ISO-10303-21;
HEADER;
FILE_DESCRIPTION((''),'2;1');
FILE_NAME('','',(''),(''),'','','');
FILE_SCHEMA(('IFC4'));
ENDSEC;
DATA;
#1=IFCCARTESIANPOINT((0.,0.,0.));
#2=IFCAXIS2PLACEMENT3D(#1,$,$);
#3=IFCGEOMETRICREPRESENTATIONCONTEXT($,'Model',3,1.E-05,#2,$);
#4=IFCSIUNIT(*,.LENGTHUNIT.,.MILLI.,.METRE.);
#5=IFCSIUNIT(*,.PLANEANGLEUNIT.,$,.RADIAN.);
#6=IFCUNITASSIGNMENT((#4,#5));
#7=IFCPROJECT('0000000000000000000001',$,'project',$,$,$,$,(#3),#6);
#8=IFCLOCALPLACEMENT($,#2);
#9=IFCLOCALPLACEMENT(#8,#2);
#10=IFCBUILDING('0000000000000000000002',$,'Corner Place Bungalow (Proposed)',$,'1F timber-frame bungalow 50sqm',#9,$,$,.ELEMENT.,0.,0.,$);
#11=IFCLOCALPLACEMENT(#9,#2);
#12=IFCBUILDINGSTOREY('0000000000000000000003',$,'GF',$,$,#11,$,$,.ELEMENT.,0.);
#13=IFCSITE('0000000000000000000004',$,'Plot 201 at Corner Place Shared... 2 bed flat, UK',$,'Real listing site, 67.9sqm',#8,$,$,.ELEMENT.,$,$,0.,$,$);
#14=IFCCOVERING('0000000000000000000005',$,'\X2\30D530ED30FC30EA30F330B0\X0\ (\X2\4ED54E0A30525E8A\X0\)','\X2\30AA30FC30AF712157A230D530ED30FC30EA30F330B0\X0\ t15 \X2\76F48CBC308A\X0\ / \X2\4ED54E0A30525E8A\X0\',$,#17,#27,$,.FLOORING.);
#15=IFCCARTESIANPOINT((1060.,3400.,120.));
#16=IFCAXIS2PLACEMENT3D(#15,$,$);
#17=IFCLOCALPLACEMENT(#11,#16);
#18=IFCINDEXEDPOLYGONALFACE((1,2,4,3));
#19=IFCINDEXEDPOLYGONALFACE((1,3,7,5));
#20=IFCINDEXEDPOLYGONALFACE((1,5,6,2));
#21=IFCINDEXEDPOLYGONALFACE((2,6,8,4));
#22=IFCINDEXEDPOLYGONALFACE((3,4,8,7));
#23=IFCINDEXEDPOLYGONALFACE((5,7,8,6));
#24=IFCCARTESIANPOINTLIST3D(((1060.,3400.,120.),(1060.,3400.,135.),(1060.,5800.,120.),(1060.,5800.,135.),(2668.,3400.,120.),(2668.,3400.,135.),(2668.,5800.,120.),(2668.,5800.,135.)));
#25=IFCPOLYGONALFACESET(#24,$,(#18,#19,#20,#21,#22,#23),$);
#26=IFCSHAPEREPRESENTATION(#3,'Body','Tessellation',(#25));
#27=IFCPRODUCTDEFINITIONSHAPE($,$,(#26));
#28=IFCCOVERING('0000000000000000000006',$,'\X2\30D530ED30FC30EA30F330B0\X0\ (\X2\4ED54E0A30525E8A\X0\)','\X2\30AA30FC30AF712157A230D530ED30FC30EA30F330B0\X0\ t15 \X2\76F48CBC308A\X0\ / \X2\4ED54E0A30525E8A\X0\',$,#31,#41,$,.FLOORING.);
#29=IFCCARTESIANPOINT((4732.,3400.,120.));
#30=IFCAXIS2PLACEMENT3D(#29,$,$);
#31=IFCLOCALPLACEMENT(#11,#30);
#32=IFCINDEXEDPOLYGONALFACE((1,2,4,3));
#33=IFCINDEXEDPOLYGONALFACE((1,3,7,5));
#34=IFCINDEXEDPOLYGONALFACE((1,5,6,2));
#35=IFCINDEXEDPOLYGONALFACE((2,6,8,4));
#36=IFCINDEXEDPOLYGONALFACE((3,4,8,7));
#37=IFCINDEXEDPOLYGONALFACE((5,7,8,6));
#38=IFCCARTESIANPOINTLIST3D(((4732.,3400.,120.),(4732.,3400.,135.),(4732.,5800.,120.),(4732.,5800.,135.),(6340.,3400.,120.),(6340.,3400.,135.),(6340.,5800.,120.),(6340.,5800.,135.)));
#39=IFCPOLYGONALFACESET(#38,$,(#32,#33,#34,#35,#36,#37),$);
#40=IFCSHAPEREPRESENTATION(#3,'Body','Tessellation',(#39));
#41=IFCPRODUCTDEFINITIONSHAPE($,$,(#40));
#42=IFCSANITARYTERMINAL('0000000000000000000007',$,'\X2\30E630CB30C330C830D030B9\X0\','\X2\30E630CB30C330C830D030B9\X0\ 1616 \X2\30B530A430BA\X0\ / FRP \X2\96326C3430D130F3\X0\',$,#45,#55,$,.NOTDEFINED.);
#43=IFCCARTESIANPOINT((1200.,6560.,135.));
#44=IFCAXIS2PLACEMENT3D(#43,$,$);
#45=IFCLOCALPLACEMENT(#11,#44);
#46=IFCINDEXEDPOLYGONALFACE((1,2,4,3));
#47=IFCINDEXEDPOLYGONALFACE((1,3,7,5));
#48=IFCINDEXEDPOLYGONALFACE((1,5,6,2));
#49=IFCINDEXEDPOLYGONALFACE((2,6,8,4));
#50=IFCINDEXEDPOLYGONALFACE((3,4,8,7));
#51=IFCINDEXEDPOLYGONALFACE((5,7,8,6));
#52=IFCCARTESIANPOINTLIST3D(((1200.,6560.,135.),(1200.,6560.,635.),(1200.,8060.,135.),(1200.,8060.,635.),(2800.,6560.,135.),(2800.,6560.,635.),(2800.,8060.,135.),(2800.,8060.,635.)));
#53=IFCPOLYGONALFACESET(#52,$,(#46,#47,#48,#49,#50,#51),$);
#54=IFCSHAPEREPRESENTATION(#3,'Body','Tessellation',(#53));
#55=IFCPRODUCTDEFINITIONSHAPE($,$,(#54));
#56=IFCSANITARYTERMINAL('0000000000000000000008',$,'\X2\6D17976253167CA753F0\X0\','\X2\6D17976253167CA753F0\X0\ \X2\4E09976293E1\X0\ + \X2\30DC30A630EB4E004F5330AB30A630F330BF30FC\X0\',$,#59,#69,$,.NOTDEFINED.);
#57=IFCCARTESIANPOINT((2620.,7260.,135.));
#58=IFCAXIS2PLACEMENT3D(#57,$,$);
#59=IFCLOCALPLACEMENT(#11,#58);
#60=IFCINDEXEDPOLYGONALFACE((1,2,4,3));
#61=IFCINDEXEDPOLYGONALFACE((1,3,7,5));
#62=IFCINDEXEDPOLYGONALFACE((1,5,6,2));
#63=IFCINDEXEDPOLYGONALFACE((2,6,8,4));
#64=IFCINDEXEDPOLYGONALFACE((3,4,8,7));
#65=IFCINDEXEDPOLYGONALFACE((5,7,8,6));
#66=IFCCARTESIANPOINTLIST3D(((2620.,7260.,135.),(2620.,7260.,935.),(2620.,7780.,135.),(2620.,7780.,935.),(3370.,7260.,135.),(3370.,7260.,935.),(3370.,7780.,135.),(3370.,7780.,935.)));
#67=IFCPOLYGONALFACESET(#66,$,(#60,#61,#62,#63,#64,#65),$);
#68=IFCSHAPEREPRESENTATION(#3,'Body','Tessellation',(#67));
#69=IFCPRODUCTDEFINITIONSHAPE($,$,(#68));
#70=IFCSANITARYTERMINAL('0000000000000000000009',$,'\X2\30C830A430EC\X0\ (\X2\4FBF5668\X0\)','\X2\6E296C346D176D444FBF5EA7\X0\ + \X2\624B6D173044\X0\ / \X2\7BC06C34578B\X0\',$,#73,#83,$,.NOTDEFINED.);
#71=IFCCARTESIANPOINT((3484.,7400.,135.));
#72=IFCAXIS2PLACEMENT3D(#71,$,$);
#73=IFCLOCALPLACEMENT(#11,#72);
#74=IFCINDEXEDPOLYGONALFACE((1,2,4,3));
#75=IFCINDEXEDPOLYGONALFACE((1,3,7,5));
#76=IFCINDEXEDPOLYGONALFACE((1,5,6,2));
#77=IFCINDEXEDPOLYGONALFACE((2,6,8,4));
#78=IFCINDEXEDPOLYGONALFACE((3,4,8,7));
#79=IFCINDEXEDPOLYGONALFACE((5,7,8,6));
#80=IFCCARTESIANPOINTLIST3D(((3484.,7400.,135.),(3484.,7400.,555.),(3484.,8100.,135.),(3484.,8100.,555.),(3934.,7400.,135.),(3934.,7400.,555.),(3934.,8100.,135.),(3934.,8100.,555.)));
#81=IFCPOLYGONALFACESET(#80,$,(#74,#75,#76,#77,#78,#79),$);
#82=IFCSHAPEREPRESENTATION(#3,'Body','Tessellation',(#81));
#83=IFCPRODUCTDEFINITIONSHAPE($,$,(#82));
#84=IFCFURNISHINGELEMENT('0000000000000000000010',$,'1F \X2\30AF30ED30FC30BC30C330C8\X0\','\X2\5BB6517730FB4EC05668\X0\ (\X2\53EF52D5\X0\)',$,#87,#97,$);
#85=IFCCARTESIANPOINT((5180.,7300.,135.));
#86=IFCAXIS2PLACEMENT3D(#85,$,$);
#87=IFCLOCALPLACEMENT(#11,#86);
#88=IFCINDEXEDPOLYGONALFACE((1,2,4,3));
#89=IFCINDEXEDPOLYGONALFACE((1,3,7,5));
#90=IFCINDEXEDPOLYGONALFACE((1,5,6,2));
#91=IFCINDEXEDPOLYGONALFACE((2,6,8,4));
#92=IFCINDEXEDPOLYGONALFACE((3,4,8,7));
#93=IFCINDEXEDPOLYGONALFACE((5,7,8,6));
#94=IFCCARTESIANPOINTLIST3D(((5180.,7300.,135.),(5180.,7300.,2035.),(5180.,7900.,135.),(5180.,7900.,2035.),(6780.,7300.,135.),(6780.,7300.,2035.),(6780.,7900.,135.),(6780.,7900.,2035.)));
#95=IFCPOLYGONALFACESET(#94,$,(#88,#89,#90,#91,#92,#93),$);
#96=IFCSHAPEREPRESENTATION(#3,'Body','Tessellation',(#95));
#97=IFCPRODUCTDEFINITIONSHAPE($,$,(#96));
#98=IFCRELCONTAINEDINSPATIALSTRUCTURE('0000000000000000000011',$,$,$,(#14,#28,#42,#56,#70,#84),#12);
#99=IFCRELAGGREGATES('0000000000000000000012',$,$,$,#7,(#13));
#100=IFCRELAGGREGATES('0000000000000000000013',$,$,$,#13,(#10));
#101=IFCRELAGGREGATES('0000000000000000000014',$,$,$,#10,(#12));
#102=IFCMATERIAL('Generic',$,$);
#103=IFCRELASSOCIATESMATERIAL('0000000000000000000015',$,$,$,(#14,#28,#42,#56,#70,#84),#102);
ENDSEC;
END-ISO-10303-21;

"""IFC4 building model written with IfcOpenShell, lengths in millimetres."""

from ifc_helpers import new_model, si_unit, frame, frame_2d, origin, place, context, project, spatial, rectangle, extrude, material, element, save


model = new_model("IFC4")

# Units and contexts
model_context = context("Model", 3, precision=1e-05, world=origin())
ifc_project = project(units=[si_unit("LENGTHUNIT", "METRE", prefix="MILLI"), si_unit("PLANEANGLEUNIT", "RADIAN")], contexts=[model_context])

# Site, building, storey
site_placement = place(None, origin())
site = spatial("IfcSite", under=ifc_project, at=site_placement, Name="Plot 201 at Corner Place Shared... 2 bed flat, UK", ObjectType="Real listing site, 67.9sqm", CompositionType="ELEMENT", RefElevation=0.0)
building_placement = place(site_placement, origin())
building = spatial("IfcBuilding", under=site, at=building_placement, Name="Corner Place Bungalow (Proposed)", ObjectType="1F timber-frame bungalow 50sqm", CompositionType="ELEMENT", ElevationOfRefHeight=0.0, ElevationOfTerrain=0.0)
storey_placement = place(building_placement, origin())
storey = spatial("IfcBuildingStorey", under=building, at=storey_placement, Name="GF", CompositionType="ELEMENT", Elevation=0.0)

# Coverings
ifc_material_1 = material(Name="Generic")
covering_1_placement = place(storey_placement, frame((1060.0, 3400.0, 120.0)))
element("IfcCovering", 1, at=covering_1_placement, inside=storey, material=ifc_material_1, Name="フローリング (仕上げ床)", Description="オーク無垢フローリング t15 直貼り / 仕上げ床", PredefinedType="FLOORING", context=model_context, shape_type="SweptSolid", body=[
    extrude(rectangle(XDim=1608.0, YDim=2400.0, at=frame_2d((804.0, 1200.0))), frame((1060.0, 3400.0, 120.0)), (0.0, 0.0, 1.0), 15.0),
])
covering_2_placement = place(storey_placement, frame((4732.0, 3400.0, 120.0)))
element("IfcCovering", 2, at=covering_2_placement, inside=storey, material=ifc_material_1, Name="フローリング (仕上げ床)", Description="オーク無垢フローリング t15 直貼り / 仕上げ床", PredefinedType="FLOORING", context=model_context, shape_type="SweptSolid", body=[
    extrude(rectangle(XDim=1608.0, YDim=2400.0, at=frame_2d((804.0, 1200.0))), frame((4732.0, 3400.0, 120.0)), (0.0, 0.0, 1.0), 15.0),
])

# Sanitary terminals
sanitary_terminal_1_placement = place(storey_placement, frame((1200.0, 6560.0, 135.0)))
element("IfcSanitaryTerminal", 3, at=sanitary_terminal_1_placement, inside=storey, material=ifc_material_1, Name="ユニットバス", Description="ユニットバス 1616 サイズ / FRP 防水パン", PredefinedType="NOTDEFINED", context=model_context, shape_type="SweptSolid", body=[
    extrude(rectangle(XDim=1600.0, YDim=1500.0, at=frame_2d((800.0, 750.0))), frame((1200.0, 6560.0, 135.0)), (0.0, 0.0, 1.0), 500.0),
])
sanitary_terminal_2_placement = place(storey_placement, frame((2620.0, 7260.0, 135.0)))
element("IfcSanitaryTerminal", 4, at=sanitary_terminal_2_placement, inside=storey, material=ifc_material_1, Name="洗面化粧台", Description="洗面化粧台 三面鏡 + ボウル一体カウンター", PredefinedType="NOTDEFINED", context=model_context, shape_type="SweptSolid", body=[
    extrude(rectangle(XDim=750.0, YDim=520.0, at=frame_2d((375.0, 260.0))), frame((2620.0, 7260.0, 135.0)), (0.0, 0.0, 1.0), 800.0),
])
sanitary_terminal_3_placement = place(storey_placement, frame((3484.0, 7400.0, 135.0)))
element("IfcSanitaryTerminal", 5, at=sanitary_terminal_3_placement, inside=storey, material=ifc_material_1, Name="トイレ (便器)", Description="温水洗浄便座 + 手洗い / 節水型", PredefinedType="NOTDEFINED", context=model_context, shape_type="SweptSolid", body=[
    extrude(rectangle(XDim=450.0, YDim=700.0, at=frame_2d((225.0, 350.0))), frame((3484.0, 7400.0, 135.0)), (0.0, 0.0, 1.0), 420.0),
])

# Furnishing element
furnishing_placement = place(storey_placement, frame((5180.0, 7300.0, 135.0)))
element("IfcFurnishingElement", 6, at=furnishing_placement, inside=storey, material=ifc_material_1, Name="1F クローゼット", Description="家具・什器 (可動)", context=model_context, shape_type="SweptSolid", body=[
    extrude(rectangle(XDim=1600.0, YDim=600.0, at=frame_2d((800.0, 300.0))), frame((5180.0, 7300.0, 135.0)), (0.0, 0.0, 1.0), 1900.0),
])

save(model, "model.ifc")
